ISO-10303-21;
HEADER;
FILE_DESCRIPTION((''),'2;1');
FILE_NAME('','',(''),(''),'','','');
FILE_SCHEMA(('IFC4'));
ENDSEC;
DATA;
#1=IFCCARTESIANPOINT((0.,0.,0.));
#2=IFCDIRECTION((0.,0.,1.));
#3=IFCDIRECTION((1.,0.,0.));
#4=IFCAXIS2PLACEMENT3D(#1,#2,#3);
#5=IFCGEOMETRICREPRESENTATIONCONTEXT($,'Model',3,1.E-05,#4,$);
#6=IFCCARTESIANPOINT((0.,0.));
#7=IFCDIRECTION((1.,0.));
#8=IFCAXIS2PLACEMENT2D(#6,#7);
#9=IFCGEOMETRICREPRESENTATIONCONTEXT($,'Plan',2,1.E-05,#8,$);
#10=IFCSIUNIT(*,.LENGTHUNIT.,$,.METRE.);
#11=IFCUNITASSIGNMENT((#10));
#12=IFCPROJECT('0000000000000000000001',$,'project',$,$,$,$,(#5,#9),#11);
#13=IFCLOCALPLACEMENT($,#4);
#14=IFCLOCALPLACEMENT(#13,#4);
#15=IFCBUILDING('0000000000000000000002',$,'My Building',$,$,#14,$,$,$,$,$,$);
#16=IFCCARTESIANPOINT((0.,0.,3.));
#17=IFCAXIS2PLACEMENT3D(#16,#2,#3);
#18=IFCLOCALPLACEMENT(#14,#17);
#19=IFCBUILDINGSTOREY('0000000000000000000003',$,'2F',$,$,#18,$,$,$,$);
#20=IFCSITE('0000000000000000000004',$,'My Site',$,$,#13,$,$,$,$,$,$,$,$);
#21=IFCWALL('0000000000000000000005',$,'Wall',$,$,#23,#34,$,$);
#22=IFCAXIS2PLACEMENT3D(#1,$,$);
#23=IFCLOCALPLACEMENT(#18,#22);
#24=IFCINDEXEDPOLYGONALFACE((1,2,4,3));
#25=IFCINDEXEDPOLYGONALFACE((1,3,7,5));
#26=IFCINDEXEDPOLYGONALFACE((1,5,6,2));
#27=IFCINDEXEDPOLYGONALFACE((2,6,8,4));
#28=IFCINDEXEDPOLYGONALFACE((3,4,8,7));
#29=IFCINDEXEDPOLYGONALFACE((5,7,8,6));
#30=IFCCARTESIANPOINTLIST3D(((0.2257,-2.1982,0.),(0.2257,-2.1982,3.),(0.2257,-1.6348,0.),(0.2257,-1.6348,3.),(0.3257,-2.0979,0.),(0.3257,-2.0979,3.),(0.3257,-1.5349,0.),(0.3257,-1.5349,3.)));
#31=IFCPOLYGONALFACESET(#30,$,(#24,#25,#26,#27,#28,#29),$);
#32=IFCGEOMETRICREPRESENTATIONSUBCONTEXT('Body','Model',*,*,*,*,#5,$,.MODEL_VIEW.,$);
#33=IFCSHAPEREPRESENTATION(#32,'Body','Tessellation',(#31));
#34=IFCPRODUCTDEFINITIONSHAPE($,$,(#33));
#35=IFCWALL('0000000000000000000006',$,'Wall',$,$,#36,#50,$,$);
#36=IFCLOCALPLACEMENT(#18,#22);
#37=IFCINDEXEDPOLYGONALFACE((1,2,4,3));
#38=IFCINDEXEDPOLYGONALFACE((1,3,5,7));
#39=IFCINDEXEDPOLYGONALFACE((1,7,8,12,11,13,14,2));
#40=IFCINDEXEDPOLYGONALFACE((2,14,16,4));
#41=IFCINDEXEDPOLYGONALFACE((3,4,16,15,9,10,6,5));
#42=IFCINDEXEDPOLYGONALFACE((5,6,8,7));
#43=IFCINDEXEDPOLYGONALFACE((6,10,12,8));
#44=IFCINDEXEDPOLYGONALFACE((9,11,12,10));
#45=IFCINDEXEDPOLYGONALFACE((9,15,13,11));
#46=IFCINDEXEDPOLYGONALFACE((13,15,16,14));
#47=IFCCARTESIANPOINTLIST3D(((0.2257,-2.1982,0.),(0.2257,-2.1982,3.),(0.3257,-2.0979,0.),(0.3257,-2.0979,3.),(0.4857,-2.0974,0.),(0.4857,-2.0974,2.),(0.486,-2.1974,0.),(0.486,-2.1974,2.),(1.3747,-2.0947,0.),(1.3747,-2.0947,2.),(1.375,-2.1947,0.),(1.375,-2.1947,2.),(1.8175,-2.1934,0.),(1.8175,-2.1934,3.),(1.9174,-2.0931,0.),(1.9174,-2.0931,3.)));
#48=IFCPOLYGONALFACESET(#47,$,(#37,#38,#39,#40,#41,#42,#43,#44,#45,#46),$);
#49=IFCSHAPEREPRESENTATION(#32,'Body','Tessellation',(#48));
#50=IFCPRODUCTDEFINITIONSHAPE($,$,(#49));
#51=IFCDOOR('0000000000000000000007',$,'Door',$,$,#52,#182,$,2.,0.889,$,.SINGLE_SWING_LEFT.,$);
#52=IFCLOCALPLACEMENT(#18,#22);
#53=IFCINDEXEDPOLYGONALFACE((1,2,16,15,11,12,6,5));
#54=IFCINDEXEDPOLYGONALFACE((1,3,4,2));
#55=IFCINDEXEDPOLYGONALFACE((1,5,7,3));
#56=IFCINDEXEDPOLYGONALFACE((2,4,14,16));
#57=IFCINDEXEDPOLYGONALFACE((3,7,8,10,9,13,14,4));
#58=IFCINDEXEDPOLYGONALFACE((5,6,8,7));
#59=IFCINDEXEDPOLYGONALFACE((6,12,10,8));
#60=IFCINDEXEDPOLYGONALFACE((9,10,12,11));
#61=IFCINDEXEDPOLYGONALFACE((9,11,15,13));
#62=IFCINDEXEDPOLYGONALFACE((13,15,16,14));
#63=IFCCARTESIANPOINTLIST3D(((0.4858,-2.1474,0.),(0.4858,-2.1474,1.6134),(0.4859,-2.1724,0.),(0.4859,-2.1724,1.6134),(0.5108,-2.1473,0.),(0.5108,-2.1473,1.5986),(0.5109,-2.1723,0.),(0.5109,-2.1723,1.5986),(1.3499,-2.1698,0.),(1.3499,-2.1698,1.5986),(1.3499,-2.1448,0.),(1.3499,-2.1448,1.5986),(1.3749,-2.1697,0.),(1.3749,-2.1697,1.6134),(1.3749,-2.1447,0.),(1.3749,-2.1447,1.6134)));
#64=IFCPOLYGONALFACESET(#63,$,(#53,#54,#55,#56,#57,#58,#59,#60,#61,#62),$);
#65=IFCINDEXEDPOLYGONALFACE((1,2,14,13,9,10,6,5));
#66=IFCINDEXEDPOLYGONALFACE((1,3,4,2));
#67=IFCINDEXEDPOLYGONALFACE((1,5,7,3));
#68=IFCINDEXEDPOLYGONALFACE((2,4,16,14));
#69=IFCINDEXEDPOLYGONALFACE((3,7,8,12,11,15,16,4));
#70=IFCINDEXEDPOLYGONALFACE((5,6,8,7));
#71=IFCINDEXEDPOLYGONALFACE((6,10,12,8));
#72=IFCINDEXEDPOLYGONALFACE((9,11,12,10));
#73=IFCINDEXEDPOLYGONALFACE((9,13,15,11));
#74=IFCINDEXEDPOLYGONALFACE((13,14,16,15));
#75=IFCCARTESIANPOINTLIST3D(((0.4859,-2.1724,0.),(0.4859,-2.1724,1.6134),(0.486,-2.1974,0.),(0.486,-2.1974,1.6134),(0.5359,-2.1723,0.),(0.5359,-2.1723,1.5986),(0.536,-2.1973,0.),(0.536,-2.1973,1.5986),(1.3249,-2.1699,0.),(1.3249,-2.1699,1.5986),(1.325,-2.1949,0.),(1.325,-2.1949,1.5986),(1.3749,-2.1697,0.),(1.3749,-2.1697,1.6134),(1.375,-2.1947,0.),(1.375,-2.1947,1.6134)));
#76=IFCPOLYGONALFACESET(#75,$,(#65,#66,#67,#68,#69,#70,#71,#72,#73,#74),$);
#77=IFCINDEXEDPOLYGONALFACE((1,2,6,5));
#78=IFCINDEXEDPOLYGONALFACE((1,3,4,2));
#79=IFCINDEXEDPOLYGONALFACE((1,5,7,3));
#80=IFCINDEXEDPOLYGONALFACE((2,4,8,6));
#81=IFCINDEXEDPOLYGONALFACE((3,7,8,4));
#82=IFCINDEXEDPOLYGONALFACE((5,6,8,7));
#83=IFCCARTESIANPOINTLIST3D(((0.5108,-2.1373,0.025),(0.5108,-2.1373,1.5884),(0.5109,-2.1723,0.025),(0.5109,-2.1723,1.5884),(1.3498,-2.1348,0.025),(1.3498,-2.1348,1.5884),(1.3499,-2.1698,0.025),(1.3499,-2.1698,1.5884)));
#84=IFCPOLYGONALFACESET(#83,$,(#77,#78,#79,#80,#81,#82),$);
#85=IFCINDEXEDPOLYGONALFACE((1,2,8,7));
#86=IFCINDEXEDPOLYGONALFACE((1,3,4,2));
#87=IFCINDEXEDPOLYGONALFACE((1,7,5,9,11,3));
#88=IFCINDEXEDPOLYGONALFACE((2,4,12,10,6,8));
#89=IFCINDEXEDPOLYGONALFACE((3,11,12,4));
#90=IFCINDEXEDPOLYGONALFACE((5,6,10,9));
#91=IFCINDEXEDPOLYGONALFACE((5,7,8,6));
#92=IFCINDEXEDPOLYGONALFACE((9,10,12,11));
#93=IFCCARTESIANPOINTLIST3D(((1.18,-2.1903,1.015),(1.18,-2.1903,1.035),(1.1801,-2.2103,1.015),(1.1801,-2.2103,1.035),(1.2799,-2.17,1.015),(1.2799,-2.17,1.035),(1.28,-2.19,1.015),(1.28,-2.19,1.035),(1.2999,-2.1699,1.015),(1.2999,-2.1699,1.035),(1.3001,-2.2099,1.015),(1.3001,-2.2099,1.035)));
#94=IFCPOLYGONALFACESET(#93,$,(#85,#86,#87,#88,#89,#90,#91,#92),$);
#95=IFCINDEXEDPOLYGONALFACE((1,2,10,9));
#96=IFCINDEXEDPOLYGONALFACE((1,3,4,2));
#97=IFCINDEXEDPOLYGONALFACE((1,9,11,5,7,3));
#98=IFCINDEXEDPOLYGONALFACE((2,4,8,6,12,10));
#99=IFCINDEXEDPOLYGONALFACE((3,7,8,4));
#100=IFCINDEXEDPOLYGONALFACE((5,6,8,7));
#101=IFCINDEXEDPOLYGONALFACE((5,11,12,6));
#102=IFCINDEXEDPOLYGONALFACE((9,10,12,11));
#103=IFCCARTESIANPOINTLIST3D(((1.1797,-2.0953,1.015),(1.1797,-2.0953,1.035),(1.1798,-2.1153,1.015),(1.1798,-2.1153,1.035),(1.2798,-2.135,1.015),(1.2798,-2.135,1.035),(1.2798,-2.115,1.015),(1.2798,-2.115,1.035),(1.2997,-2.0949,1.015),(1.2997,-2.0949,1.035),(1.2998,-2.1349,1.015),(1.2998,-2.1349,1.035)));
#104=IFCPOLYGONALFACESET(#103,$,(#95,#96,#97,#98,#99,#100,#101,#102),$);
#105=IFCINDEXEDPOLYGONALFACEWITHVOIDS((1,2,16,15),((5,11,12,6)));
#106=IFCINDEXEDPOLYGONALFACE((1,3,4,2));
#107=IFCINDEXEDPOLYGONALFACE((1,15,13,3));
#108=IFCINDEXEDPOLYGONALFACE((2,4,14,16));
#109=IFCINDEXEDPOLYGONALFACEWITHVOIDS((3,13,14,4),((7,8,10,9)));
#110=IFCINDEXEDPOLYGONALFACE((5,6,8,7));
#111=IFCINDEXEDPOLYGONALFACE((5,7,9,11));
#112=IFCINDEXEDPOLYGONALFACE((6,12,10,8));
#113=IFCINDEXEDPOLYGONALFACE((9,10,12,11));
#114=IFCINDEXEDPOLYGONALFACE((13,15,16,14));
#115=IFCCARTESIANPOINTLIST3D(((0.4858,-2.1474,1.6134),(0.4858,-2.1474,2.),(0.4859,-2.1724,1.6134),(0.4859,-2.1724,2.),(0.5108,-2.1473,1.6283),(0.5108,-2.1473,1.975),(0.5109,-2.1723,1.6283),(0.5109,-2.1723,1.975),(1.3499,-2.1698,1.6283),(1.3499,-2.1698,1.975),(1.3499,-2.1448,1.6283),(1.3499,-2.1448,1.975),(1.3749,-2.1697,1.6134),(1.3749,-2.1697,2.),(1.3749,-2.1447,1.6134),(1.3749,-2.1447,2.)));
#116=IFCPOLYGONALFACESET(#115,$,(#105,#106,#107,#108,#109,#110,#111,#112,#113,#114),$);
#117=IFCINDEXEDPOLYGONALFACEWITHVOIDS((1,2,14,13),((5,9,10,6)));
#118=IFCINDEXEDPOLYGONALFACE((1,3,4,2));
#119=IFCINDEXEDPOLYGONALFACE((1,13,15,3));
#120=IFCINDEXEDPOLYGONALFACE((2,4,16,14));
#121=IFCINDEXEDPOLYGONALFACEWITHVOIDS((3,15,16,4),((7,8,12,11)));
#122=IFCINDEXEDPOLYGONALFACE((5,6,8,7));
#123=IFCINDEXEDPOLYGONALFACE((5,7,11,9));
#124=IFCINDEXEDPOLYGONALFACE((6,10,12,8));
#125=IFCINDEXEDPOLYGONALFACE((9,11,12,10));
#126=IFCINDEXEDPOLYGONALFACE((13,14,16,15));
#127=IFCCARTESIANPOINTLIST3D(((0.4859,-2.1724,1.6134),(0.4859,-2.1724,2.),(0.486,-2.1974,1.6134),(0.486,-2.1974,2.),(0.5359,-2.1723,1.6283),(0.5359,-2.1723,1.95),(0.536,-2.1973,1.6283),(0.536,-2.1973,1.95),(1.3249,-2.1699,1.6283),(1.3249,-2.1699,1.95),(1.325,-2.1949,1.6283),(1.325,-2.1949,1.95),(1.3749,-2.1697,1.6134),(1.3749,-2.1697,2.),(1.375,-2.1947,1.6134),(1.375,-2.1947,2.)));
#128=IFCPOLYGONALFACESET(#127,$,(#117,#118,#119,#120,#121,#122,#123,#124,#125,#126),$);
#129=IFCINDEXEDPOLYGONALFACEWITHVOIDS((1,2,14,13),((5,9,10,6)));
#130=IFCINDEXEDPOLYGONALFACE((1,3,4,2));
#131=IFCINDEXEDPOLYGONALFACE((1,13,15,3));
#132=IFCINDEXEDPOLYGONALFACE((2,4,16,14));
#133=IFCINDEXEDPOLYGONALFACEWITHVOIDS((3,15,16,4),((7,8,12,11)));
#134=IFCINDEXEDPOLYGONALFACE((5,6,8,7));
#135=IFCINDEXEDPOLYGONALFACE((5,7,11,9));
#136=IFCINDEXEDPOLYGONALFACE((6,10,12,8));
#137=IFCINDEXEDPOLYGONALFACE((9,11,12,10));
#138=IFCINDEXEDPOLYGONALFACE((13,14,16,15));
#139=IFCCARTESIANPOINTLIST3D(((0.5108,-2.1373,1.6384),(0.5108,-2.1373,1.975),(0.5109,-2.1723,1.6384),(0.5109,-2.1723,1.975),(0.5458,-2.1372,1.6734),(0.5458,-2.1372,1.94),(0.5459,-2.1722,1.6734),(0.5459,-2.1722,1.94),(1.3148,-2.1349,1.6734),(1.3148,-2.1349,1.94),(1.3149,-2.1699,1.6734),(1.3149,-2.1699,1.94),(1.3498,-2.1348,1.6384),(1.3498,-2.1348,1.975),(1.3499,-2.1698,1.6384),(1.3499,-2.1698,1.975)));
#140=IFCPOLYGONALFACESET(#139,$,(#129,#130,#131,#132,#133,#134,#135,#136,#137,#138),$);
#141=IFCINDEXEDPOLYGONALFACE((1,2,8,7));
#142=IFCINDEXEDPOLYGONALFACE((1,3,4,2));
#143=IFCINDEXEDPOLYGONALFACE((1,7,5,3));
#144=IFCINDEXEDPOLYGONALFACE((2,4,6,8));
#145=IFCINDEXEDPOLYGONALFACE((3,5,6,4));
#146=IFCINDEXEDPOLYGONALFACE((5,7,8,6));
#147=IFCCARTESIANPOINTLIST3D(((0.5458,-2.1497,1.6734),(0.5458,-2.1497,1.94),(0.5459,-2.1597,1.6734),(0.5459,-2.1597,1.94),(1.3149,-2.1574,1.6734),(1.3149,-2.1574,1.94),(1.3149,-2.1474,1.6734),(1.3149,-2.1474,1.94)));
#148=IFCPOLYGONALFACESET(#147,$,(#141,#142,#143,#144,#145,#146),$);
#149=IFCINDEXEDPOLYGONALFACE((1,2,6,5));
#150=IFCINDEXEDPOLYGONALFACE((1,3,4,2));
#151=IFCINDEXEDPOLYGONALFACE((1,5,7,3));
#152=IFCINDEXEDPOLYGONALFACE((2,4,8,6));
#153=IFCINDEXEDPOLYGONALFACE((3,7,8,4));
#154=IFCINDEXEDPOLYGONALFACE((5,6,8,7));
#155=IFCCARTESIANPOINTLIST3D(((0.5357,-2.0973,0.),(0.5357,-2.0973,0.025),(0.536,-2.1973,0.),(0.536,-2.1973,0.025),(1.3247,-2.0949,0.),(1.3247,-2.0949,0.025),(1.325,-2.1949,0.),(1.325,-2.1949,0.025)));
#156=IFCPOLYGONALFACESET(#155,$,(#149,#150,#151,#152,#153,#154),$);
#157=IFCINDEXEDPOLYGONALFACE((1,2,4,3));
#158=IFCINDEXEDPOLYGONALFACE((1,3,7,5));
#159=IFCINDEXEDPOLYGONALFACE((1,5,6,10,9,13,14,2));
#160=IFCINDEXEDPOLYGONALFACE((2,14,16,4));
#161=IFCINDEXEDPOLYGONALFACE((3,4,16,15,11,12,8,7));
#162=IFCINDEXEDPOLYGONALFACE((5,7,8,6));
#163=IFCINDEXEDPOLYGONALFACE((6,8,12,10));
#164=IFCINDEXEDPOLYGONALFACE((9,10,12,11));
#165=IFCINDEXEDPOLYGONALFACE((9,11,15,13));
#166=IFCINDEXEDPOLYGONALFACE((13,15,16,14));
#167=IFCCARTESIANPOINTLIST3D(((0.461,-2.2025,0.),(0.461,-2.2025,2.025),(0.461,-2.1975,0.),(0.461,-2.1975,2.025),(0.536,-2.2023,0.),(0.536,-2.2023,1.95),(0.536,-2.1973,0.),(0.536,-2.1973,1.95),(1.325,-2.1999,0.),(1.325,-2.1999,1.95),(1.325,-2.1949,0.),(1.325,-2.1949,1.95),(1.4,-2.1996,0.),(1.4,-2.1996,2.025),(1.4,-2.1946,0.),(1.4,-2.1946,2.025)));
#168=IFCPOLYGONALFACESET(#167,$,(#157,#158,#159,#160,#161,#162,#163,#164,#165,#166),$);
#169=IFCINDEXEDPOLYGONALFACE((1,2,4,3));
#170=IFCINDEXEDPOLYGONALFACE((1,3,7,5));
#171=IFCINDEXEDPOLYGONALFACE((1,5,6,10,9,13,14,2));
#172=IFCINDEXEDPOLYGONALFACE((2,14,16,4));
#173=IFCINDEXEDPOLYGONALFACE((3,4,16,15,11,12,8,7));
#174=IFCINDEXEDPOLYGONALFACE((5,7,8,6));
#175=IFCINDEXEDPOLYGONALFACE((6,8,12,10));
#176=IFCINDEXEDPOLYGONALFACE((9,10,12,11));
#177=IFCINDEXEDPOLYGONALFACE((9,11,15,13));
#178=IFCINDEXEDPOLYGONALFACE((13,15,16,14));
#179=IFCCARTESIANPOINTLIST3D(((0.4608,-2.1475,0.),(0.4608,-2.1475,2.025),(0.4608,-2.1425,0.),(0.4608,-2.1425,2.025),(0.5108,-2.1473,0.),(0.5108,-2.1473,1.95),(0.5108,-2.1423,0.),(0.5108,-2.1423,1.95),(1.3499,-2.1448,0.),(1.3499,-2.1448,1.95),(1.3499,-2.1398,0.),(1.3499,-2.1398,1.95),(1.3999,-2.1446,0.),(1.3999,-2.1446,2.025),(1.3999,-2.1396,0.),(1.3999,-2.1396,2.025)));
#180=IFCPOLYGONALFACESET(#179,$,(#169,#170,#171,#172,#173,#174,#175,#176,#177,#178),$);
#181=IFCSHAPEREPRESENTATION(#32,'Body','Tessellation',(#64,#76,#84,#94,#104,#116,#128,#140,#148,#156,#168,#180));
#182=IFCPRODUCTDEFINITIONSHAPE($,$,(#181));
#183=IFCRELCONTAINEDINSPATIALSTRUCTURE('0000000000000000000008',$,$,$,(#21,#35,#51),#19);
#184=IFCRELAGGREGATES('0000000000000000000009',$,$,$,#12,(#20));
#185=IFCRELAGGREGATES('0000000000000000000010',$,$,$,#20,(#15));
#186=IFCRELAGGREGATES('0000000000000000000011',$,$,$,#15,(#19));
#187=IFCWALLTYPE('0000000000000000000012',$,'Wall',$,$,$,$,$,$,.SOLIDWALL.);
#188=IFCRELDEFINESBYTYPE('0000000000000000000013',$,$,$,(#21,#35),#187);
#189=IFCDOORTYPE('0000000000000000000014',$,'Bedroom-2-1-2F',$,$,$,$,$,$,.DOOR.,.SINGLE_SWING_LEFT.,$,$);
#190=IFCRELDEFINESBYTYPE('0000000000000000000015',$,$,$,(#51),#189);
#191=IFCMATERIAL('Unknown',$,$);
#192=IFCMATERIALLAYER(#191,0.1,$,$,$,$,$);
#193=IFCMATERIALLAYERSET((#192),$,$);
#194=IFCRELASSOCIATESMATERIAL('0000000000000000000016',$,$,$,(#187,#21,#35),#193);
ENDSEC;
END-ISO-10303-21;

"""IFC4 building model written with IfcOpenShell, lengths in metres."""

from ifc_helpers import new_model, entity, si_unit, frame, origin_with_axes, origin_2d_with_axis, place, context, subcontext, project, spatial, line, indexed_curve, outline, extrude, shape, source, transform, mapped, material, layer, layer_set, layer_usage, type_object, type_shapes, element, fill, save


model = new_model("IFC4")

# Units and contexts
model_context = context("Model", 3, precision=1e-05, world=origin_with_axes())
plan_context = context("Plan", 2, precision=1e-05, world=origin_2d_with_axis())
body_context_1 = subcontext(model_context, "Body", "Model", "MODEL_VIEW")
body_context_2 = subcontext(plan_context, "Body", "Plan", "PLAN_VIEW")
ifc_project = project(units=[si_unit("LENGTHUNIT", "METRE")], contexts=[model_context, plan_context])

# Site, building, storey
site_placement = place(None, origin_with_axes())
site = spatial("IfcSite", under=ifc_project, at=site_placement, Name="My Site")
building_placement = place(site_placement, origin_with_axes())
building = spatial("IfcBuilding", under=site, at=building_placement, Name="My Building")
storey_placement = place(building_placement, frame((0.0, 0.0, 3.0), z_axis=(0.0, 0.0, 1.0), x_axis=(1.0, 0.0, 0.0)))
storey = spatial("IfcBuildingStorey", under=building, at=storey_placement, Name="2F")

# Shared definitions
ifc_material = material(Name="Unknown")

# Shared definitions
ifc_layer = layer(ifc_material, 0.1)
ifc_layer_set = layer_set([ifc_layer])
wall_type = type_object("IfcWallType", Name="Wall", PredefinedType="SOLIDWALL", material=ifc_layer_set)

# Wall
ifc_layer_usage_1 = layer_usage(ifc_layer_set, "AXIS2", "POSITIVE", 0.0)
wall_1_placement = place(storey_placement, frame((0.2257, -1.6348, 0.0), z_axis=(0.0, 0.0, 1.0), x_axis=(0.0, -1.0, 0.0)))
element("IfcWall", 1, at=wall_1_placement, inside=storey, type_object=wall_type, material=ifc_layer_usage_1, Name="Wall", context=body_context_1, shape_type="SweptSolid", body=[
    extrude(outline(indexed_curve([(0.0, 0.0), (-0.0999, 0.1), (0.4631, 0.1), (0.5634, 0.0)], segments=[line(1, 2, 3, 4, 1)])), origin_with_axes(), (0.0, 0.0, 1.0), 3.0),
])

# Wall, opening, door
ifc_layer_usage_2 = layer_usage(ifc_layer_set, "AXIS2", "POSITIVE", 0.0)
wall_2_placement = place(storey_placement, frame((0.2257, -2.1982, 0.0), z_axis=(0.0, 0.0, 1.0), x_axis=(0.999995, 0.003047, 0.0)))
wall_2 = element("IfcWall", 2, at=wall_2_placement, inside=storey, type_object=wall_type, material=ifc_layer_usage_2, Name="Wall", context=body_context_1, shape_type="SweptSolid", body=[
    extrude(outline(indexed_curve([(0.0, 0.0), (0.1003, 0.1), (1.692, 0.1), (1.5917, 0.0)], segments=[line(1, 2, 3, 4, 1)])), origin_with_axes(), (0.0, 0.0, 1.0), 3.0),
])
shared_shape_1 = source(origin_with_axes(), body_context_1, "Body", "SweptSolid", [
    extrude(outline(indexed_curve([(0.0, 0.0), (0.889, 0.0), (0.889, 2.0), (0.0, 2.0)], segments=[line(1, 2, 3, 4, 1)])), frame((0.0, -0.6, 0.0), z_axis=(0.0, -1.0, 0.0), x_axis=(1.0, 0.0, 0.0)), (0.0, 0.0, -1.0), 1.2),
])
opening_1_placement = place(wall_2_placement, frame((0.2603, 0.0, 0.0), z_axis=(0.0, 0.0, 1.0), x_axis=(1.0, 0.0, 0.0)))
opening_1 = element("IfcOpeningElement", 3, at=opening_1_placement, cuts=wall_2, PredefinedType="OPENING", context=body_context_1, shape_type="MappedRepresentation", body=[
    mapped(shared_shape_1, transform((0.0, 0.0, 0.0), x_axis=(1.0, 0.0, 0.0), y_axis=(0.0, 1.0, 0.0), z_axis=(0.0, 0.0, 1.0), scale=1.0)),
])
door_type_1 = type_object("IfcDoorType", Name="Bedroom-2-1-2F", OperationType="SINGLE_SWING_LEFT", PredefinedType="DOOR")
shared_shape_2 = source(origin_with_axes(), body_context_1, "Body", "SweptSolid", [
    extrude(outline(indexed_curve([(0.0, 0.0), (0.0, 1.6134), (0.889, 1.6134), (0.889, 0.0), (0.864, 0.0), (0.864, 1.5986), (0.025, 1.5986), (0.025, 0.0)], segments=[line(1, 2, 3, 4, 5, 6, 7, 8, 1)])), frame((0.0, 0.025, 0.0), z_axis=(0.0, -1.0, 0.0), x_axis=(1.0, 0.0, 0.0)), (0.0, 0.0, -1.0), 0.025),
    extrude(outline(indexed_curve([(0.0, 0.0), (0.0, 1.6134), (0.889, 1.6134), (0.889, 0.0), (0.839, 0.0), (0.839, 1.5986), (0.05, 1.5986), (0.05, 0.0)], segments=[line(1, 2, 3, 4, 5, 6, 7, 8, 1)])), frame((0.0, 0.0, 0.0), z_axis=(0.0, -1.0, 0.0), x_axis=(1.0, 0.0, 0.0)), (0.0, 0.0, -1.0), 0.025),
    extrude(outline(indexed_curve([(0.0, 0.0), (0.839, 0.0), (0.839, 0.035), (0.0, 0.035)], segments=[line(1, 2, 3, 4, 1)])), frame((0.025, 0.025, 0.025), z_axis=(0.0, 0.0, 1.0), x_axis=(1.0, 0.0, 0.0)), (0.0, 0.0, 1.0), 1.5634),
    extrude(outline(indexed_curve([(0.0, 0.0), (0.0, -0.04), (-0.12, -0.04), (-0.12, -0.02), (-0.02, -0.02), (-0.02, 0.0)], segments=[line(1, 2, 3, 4, 5, 6, 1)])), frame((0.814, 0.025, 1.015), z_axis=(0.0, 0.0, 1.0), x_axis=(1.0, 0.0, 0.0)), (0.0, 0.0, 1.0), 0.02),
    extrude(outline(indexed_curve([(0.0, 0.0), (0.0, 0.04), (-0.12, 0.04), (-0.12, 0.02), (-0.02, 0.02), (-0.02, 0.0)], segments=[line(1, 2, 3, 4, 5, 6, 1)])), frame((0.814, 0.06, 1.015), z_axis=(0.0, 0.0, 1.0), x_axis=(1.0, 0.0, 0.0)), (0.0, 0.0, 1.0), 0.02),
    extrude(outline(indexed_curve([(0.0, 0.0), (0.889, 0.0), (0.889, 0.3866), (0.0, 0.3866)], segments=[line(1, 2, 3, 4, 1)]), holes=[indexed_curve([(0.025, 0.0148), (0.864, 0.0148), (0.864, 0.3616), (0.025, 0.3616)], segments=[line(1, 2, 3, 4, 1)])]), frame((0.0, 0.025, 1.6134), z_axis=(0.0, -1.0, 0.0), x_axis=(1.0, 0.0, 0.0)), (0.0, 0.0, -1.0), 0.025),
    extrude(outline(indexed_curve([(0.0, 0.0), (0.889, 0.0), (0.889, 0.3866), (0.0, 0.3866)], segments=[line(1, 2, 3, 4, 1)]), holes=[indexed_curve([(0.05, 0.0148), (0.839, 0.0148), (0.839, 0.3366), (0.05, 0.3366)], segments=[line(1, 2, 3, 4, 1)])]), frame((0.0, 0.0, 1.6134), z_axis=(0.0, -1.0, 0.0), x_axis=(1.0, 0.0, 0.0)), (0.0, 0.0, -1.0), 0.025),
    extrude(outline(indexed_curve([(0.0, 0.0), (0.839, 0.0), (0.839, 0.3366), (0.0, 0.3366)], segments=[line(1, 2, 3, 4, 1)]), holes=[indexed_curve([(0.035, 0.035), (0.804, 0.035), (0.804, 0.3016), (0.035, 0.3016)], segments=[line(1, 2, 3, 4, 1)])]), frame((0.025, 0.025, 1.6384), z_axis=(0.0, -1.0, 0.0), x_axis=(1.0, 0.0, 0.0)), (0.0, 0.0, -1.0), 0.035),
    extrude(outline(indexed_curve([(0.035, 0.035), (0.804, 0.035), (0.804, 0.3016), (0.035, 0.3016)], segments=[line(1, 2, 3, 4, 1)])), frame((0.025, 0.0375, 1.6384), z_axis=(0.0, -1.0, 0.0), x_axis=(1.0, 0.0, 0.0)), (0.0, 0.0, -1.0), 0.01),
    extrude(outline(indexed_curve([(0.0, 0.0), (0.789, 0.0), (0.789, 0.1), (0.0, 0.1)], segments=[line(1, 2, 3, 4, 1)])), frame((0.05, 0.0, 0.0), z_axis=(0.0, 0.0, 1.0), x_axis=(1.0, 0.0, 0.0)), (0.0, 0.0, 1.0), 0.025),
    extrude(outline(indexed_curve([(0.0, 0.0), (0.0, 2.025), (0.939, 2.025), (0.939, 0.0), (0.864, 0.0), (0.864, 1.95), (0.075, 1.95), (0.075, 0.0)], segments=[line(1, 2, 3, 4, 5, 6, 7, 8, 1)])), frame((-0.025, -0.005, 0.0), z_axis=(0.0, -1.0, 0.0), x_axis=(1.0, 0.0, 0.0)), (0.0, 0.0, -1.0), 0.005),
    extrude(outline(indexed_curve([(0.0, 0.0), (0.0, 2.025), (0.939, 2.025), (0.939, 0.0), (0.889, 0.0), (0.889, 1.95), (0.05, 1.95), (0.05, 0.0)], segments=[line(1, 2, 3, 4, 5, 6, 7, 8, 1)])), frame((-0.025, 0.05, 0.0), z_axis=(0.0, -1.0, 0.0), x_axis=(1.0, 0.0, 0.0)), (0.0, 0.0, -1.0), 0.005),
])
shared_shape_3 = source(origin_with_axes(), body_context_2, "Body", "Curve2D", [
    entity("IfcIndexedPolyCurve", entity("IfcCartesianPointList2D", [[0.0, 0.0], [0.0, 0.05], [0.025, 0.05], [0.025, 0.025], [0.05, 0.025], [0.05, 0.0]]), [entity("IfcLineIndex", [1, 2, 3, 4, 5, 6, 1])]),
    entity("IfcIndexedPolyCurve", entity("IfcCartesianPointList2D", [[0.889, 0.0], [0.889, 0.05], [0.864, 0.05], [0.864, 0.025], [0.839, 0.025], [0.839, 0.0]]), [entity("IfcLineIndex", [1, 2, 3, 4, 5, 6, 1])]),
    entity("IfcTrimmedCurve", entity("IfcEllipse", entity("IfcAxis2Placement2D", entity("IfcCartesianPoint", [0.06, 0.05]), entity("IfcDirection", [1.0, 0.0])), 0.804, 0.839), [entity("IfcCartesianPoint", [0.864, 0.05])], [entity("IfcCartesianPoint", [0.06, 0.889])], True, "CARTESIAN"),
    entity("IfcIndexedPolyCurve", entity("IfcCartesianPointList2D", [[0.025, 0.05], [0.06, 0.05], [0.06, 0.889], [0.025, 0.889]]), [entity("IfcLineIndex", [1, 2, 3, 4, 1])]),
])
type_shapes(door_type_1, [shared_shape_2, shared_shape_3])
door_1_placement = place(opening_1_placement, frame((0.0, 0.0, 0.0), z_axis=(0.0, 0.0, 1.0), x_axis=(1.0, 0.0, 0.0)))
door_1 = element("IfcDoor", 4, at=door_1_placement, inside=storey, type_object=door_type_1, Name="Door", OperationType="SINGLE_SWING_LEFT", OverallHeight=2.0, OverallWidth=0.889, shapes=[
    shape(body_context_1, "Body", "MappedRepresentation", [mapped(shared_shape_2, transform((0.0, 0.0, 0.0), x_axis=(1.0, 0.0, 0.0), y_axis=(0.0, 1.0, 0.0), z_axis=(0.0, 0.0, 1.0), scale=1.0))]),
    shape(body_context_2, "Body", "MappedRepresentation", [mapped(shared_shape_3, transform((0.0, 0.0, 0.0), x_axis=(1.0, 0.0, 0.0), y_axis=(0.0, 1.0, 0.0), z_axis=(0.0, 0.0, 1.0), scale=1.0))]),
])
fill(opening_1, door_1)

save(model, "model.ifc")
